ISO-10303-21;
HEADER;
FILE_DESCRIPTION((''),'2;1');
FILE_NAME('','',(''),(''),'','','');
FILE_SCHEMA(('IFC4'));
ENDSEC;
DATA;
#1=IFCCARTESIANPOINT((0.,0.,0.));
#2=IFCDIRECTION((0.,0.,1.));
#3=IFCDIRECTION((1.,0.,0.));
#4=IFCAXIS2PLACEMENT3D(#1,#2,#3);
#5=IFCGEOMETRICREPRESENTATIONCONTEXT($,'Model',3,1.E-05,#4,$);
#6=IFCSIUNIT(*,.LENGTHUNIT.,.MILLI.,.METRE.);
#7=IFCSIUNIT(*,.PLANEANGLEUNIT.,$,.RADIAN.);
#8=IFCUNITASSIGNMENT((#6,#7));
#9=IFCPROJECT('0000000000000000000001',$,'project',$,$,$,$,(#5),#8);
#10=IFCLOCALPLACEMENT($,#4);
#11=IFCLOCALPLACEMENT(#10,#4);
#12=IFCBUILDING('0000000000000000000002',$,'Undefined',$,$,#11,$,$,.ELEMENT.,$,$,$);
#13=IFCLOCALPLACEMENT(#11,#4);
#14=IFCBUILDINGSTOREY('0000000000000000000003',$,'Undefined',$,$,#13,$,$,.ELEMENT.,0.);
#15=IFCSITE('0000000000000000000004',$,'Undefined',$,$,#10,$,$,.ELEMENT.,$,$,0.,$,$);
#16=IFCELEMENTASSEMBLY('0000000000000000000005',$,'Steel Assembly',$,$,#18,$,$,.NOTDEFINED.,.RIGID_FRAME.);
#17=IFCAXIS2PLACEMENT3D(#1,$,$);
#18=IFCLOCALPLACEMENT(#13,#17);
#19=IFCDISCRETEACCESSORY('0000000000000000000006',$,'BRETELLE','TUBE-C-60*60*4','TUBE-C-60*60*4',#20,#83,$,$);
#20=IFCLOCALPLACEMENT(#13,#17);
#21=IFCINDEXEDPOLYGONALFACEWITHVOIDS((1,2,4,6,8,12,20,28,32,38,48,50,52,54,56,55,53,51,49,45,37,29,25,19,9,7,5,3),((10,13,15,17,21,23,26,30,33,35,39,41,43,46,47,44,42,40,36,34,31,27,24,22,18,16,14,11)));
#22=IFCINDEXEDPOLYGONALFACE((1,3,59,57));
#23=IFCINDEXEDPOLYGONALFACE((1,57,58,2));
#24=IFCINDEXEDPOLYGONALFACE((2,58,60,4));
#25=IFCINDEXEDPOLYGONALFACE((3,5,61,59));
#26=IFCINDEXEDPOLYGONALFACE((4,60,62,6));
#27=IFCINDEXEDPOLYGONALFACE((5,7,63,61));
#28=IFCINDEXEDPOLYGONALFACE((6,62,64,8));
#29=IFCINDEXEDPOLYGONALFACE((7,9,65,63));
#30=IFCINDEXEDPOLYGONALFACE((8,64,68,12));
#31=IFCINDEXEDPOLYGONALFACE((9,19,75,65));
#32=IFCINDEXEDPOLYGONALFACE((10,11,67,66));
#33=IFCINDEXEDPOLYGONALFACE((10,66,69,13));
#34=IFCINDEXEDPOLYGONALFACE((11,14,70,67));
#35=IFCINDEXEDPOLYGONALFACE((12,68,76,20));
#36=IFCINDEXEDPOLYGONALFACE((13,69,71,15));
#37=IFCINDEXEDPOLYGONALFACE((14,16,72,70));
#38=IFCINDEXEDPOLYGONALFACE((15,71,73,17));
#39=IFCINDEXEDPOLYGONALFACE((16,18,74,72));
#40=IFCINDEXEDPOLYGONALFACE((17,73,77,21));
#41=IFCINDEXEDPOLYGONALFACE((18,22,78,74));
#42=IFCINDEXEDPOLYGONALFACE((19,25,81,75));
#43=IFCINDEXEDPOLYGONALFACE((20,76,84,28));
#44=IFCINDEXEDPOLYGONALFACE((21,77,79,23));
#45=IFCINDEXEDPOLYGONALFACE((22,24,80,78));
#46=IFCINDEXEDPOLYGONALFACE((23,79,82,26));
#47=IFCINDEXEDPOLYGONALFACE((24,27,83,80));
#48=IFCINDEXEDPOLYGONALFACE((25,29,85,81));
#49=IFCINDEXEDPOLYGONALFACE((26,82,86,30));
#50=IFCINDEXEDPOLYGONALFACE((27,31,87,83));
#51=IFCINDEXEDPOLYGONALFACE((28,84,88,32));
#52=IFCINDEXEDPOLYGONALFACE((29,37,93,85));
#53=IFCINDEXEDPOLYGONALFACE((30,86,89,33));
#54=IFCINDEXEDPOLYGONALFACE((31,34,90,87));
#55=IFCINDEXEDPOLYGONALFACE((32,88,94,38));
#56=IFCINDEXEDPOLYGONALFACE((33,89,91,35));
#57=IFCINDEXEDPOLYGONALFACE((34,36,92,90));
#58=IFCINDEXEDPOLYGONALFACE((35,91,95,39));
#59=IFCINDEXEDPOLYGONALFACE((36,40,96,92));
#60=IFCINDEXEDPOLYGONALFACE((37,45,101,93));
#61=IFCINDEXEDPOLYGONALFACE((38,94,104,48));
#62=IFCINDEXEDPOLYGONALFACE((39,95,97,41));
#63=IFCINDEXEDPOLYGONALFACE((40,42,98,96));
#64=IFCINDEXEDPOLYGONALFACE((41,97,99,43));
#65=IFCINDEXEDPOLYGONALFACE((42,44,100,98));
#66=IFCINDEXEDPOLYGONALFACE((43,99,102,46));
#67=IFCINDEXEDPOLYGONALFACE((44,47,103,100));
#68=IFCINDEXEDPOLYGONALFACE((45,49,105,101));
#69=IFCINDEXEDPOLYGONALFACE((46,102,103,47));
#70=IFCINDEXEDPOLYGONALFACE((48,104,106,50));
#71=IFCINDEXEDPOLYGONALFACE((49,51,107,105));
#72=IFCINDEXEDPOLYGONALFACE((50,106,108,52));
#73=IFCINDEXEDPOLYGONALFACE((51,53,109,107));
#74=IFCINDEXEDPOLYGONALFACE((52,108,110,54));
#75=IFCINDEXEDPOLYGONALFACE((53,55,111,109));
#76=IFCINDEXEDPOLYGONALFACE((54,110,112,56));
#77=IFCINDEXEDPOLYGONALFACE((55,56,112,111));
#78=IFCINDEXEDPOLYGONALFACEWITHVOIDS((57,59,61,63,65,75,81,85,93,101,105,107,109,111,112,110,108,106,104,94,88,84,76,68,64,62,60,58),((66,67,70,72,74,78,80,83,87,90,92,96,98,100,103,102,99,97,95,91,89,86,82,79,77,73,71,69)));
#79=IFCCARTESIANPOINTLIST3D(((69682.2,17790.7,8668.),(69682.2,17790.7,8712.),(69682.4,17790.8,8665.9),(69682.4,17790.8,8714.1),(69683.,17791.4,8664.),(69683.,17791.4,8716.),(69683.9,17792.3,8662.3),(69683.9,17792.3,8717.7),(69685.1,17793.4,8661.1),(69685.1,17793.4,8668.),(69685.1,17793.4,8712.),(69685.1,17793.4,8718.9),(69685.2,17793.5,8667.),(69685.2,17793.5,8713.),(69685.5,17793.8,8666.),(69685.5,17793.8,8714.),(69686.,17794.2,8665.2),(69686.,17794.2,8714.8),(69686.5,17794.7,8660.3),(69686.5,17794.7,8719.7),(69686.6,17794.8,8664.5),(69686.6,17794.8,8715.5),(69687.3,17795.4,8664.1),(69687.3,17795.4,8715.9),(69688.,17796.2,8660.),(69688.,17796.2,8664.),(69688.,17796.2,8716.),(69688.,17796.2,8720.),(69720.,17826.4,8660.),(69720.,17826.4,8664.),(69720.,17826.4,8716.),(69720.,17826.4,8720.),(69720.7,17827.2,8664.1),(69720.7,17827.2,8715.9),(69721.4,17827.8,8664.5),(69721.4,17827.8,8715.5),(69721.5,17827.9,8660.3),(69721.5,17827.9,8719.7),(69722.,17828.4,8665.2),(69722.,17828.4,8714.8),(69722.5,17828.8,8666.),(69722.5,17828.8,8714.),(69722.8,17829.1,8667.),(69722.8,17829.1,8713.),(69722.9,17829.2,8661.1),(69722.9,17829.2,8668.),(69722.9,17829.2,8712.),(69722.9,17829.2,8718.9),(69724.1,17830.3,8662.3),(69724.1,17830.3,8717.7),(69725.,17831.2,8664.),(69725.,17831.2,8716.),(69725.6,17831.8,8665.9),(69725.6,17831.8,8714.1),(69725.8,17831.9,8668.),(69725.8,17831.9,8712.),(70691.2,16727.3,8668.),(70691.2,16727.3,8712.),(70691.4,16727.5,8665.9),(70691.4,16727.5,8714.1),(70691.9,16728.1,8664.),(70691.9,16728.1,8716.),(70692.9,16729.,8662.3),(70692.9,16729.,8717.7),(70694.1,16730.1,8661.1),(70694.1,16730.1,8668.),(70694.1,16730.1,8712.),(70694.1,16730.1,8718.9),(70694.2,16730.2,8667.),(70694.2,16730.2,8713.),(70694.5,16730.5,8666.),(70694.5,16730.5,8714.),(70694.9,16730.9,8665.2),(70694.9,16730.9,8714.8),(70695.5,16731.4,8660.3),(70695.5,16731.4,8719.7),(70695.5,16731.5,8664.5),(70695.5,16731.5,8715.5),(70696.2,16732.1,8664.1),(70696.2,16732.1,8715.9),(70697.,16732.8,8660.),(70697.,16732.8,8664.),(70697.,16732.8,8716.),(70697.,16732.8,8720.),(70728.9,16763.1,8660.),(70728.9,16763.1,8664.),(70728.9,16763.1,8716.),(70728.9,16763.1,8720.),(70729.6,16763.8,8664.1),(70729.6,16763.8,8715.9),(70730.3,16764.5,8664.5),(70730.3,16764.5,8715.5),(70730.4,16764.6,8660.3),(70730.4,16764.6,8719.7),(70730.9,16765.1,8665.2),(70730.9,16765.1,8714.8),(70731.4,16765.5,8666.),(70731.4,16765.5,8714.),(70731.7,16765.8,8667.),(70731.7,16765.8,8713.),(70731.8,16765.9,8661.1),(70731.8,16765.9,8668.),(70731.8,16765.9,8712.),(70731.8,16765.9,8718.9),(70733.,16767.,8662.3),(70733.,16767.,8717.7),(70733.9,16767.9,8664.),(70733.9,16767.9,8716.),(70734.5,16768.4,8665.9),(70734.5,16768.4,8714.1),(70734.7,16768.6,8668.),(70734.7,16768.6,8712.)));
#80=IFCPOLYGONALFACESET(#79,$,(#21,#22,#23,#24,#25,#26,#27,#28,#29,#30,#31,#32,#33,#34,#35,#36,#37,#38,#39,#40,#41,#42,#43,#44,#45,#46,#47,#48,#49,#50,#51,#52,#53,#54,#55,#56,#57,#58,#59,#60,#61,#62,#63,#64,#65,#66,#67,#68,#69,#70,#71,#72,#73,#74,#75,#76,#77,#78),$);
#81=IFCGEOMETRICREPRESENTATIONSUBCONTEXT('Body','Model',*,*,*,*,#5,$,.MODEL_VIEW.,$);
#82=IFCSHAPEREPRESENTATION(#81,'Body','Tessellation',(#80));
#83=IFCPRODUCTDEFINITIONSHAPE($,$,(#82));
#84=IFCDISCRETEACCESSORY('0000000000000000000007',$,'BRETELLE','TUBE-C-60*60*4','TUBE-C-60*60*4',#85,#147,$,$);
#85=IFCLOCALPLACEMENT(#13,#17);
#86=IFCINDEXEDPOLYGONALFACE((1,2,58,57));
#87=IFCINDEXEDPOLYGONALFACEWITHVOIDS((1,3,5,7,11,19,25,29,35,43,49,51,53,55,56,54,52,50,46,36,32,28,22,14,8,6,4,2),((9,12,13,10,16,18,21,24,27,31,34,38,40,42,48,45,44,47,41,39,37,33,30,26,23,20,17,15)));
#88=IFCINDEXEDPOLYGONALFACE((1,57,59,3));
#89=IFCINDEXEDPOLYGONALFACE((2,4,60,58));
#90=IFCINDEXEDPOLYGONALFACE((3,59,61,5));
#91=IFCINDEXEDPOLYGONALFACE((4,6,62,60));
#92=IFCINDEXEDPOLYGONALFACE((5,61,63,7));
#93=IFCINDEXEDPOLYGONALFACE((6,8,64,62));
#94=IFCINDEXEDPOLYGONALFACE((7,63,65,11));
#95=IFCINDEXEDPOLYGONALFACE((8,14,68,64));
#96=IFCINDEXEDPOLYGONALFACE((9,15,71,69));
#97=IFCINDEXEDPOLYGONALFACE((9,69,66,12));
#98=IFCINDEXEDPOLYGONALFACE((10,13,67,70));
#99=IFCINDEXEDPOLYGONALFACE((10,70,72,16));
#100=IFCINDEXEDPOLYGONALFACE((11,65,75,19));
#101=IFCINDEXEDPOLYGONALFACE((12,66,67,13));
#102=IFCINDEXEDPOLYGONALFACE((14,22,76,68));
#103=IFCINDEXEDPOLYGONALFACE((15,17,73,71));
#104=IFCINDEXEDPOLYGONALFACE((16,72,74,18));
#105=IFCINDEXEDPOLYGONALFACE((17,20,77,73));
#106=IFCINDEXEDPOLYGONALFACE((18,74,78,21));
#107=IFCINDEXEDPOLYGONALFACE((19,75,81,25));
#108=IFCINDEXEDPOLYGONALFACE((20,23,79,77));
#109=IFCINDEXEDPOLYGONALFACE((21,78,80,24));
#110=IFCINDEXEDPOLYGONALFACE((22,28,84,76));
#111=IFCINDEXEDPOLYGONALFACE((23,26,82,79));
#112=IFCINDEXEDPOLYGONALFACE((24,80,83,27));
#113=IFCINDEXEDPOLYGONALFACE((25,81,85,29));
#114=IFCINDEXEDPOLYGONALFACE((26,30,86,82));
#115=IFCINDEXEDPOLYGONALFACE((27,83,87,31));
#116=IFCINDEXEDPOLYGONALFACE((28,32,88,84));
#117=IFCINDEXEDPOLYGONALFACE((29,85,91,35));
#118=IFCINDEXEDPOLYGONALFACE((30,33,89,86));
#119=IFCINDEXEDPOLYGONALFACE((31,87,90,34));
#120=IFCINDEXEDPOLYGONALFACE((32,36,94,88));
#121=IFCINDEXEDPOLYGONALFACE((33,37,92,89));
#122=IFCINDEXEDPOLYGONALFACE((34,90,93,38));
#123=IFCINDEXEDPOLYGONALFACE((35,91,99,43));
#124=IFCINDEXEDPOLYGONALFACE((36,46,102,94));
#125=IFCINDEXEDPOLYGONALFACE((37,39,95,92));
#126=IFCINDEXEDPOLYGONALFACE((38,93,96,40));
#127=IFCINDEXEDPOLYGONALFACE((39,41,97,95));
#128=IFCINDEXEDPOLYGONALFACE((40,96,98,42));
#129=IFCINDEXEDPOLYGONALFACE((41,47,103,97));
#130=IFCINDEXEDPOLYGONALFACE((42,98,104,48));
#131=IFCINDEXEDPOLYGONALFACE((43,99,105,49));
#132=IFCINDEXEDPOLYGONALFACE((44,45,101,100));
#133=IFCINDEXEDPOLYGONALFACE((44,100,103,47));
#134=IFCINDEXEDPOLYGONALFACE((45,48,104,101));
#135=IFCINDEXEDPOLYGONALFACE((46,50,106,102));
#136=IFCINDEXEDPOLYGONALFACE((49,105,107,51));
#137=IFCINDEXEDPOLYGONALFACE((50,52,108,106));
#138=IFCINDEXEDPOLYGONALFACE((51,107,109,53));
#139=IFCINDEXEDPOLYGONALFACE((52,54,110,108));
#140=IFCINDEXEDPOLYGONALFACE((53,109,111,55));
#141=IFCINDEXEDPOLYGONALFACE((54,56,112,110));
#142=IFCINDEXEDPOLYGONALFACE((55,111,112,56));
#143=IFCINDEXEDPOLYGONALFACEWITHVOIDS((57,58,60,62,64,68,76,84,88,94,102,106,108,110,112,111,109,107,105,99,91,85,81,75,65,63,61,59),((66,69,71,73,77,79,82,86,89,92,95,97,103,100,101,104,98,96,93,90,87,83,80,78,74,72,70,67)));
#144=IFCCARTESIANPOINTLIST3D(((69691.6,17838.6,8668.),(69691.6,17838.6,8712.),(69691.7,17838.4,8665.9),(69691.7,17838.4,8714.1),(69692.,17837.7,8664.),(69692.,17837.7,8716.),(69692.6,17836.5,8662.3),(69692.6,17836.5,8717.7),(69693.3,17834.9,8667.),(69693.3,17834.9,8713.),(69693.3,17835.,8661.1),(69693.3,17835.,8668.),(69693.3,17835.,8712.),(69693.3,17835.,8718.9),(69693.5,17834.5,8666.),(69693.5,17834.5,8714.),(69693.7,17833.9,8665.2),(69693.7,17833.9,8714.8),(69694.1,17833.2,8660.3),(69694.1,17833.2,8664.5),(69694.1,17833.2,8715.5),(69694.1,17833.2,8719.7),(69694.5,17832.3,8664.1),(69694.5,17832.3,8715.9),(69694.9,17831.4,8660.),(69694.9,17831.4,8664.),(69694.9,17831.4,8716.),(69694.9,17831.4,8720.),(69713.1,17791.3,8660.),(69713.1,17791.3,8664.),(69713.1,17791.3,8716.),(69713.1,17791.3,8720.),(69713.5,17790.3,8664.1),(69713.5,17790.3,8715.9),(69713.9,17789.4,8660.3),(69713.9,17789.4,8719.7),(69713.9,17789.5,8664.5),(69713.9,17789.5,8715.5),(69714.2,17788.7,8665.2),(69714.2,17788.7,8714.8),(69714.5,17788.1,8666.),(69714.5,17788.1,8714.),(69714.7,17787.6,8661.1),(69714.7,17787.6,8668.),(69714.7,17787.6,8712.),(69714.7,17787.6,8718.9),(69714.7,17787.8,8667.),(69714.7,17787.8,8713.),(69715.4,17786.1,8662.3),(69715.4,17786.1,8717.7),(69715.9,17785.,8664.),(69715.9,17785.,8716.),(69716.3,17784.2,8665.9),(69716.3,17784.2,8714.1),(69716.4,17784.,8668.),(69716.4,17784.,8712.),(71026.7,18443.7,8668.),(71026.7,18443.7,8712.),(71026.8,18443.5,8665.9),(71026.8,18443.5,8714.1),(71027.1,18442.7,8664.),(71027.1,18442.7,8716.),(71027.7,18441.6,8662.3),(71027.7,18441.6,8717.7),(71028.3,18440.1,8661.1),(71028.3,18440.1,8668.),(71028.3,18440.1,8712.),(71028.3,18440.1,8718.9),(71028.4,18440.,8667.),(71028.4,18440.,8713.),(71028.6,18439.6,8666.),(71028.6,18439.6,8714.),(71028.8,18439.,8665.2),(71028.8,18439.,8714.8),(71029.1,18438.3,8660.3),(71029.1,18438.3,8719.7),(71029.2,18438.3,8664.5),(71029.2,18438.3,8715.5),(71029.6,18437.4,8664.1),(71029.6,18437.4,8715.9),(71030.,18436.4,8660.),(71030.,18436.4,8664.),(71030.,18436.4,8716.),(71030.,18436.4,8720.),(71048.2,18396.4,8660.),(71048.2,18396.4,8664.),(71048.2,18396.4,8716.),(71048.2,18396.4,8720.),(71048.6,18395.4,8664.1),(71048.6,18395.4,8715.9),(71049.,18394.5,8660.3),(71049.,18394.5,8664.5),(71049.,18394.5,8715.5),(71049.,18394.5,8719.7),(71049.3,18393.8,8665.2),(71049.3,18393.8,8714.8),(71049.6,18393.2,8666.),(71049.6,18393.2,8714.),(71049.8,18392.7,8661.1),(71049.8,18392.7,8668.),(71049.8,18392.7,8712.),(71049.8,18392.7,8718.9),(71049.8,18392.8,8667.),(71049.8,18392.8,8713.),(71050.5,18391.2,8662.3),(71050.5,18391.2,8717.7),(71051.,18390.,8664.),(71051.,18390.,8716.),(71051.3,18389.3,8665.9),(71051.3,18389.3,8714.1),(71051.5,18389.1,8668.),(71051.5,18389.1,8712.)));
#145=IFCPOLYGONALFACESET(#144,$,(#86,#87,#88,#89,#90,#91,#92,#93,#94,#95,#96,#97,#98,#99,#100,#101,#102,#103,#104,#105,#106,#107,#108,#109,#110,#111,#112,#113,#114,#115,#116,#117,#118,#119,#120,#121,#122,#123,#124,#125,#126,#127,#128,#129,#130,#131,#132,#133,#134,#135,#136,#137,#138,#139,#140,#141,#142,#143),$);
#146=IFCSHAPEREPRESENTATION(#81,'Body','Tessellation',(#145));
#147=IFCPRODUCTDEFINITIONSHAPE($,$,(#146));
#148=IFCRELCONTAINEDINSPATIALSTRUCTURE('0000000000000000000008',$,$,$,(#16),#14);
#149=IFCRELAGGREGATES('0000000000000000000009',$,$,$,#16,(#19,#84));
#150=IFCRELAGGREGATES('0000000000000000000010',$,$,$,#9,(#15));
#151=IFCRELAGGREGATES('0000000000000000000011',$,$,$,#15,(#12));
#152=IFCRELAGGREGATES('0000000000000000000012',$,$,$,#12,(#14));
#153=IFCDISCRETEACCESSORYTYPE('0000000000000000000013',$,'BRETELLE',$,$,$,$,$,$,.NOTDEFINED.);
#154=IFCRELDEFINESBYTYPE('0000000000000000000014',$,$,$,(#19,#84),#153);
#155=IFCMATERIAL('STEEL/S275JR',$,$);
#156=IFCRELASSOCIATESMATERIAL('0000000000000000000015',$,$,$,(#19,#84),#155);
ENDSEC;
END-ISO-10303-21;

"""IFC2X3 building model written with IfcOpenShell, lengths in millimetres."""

from ifc_helpers import new_model, si_unit, frame, origin_with_axes, origin_2d_with_axis, place, context, subcontext, project, spatial, hollow_rectangle, extrude, material, type_object, element, aggregate, save


model = new_model("IFC2X3")

# Units and contexts
model_context = context("Model", 3, precision=1e-05, world=origin_with_axes())
body_context = subcontext(model_context, "Body", "Model", "MODEL_VIEW")
ifc_project = project(units=[si_unit("LENGTHUNIT", "METRE", prefix="MILLI"), si_unit("PLANEANGLEUNIT", "RADIAN")], contexts=[model_context])

# Site, building, storey
site_placement = place(None, origin_with_axes())
site = spatial("IfcSite", under=ifc_project, at=site_placement, Name="Undefined", CompositionType="ELEMENT", RefElevation=0.0)
building_placement = place(site_placement, origin_with_axes())
building = spatial("IfcBuilding", under=site, at=building_placement, Name="Undefined", CompositionType="ELEMENT")
storey_placement = place(building_placement, origin_with_axes())
storey = spatial("IfcBuildingStorey", under=building, at=storey_placement, Name="Undefined", CompositionType="ELEMENT", Elevation=0.0)

# Shared definitions
ifc_material = material(Name="STEEL/S275JR")

# Element assembly, discrete accessories
assembly_1_placement = place(storey_placement, origin_with_axes())
assembly_1 = element("IfcElementAssembly", 1, at=assembly_1_placement, inside=storey, Name="Steel Assembly", AssemblyPlace="NOTDEFINED", PredefinedType="RIGID_FRAME")
discrete_accessory_type_1 = type_object("IfcDiscreteAccessoryType", Name="BRETELLE")
discrete_accessory_1_placement = place(assembly_1_placement, frame((69704.0, 17811.3, 8690.0), z_axis=(0.725415, 0.688312, 0.0), x_axis=(0.688312, -0.725415, 0.0)))
discrete_accessory_1 = element("IfcDiscreteAccessory", 2, at=discrete_accessory_1_placement, type_object=discrete_accessory_type_1, material=ifc_material, Name="BRETELLE", Description="TUBE-C-60*60*4", ObjectType="TUBE-C-60*60*4", context=body_context, shape_type="SweptSolid", body=[
    extrude(hollow_rectangle(XDim=60.0, YDim=60.0, WallThickness=4.0, InnerFilletRadius=4.0, OuterFilletRadius=8.0, at=origin_2d_with_axis()), frame((1465.8, 0.0, 0.0), z_axis=(-1.0, 0.0, 0.0), x_axis=(0.0, -1.0, 0.0)), (0.0, 0.0, 1.0), 1465.8),
])
discrete_accessory_2_placement = place(assembly_1_placement, frame((71039.1, 18416.4, 8690.0), z_axis=(-0.412798, 0.910823, 0.0), x_axis=(-0.910823, -0.412798, 0.0)))
discrete_accessory_2 = element("IfcDiscreteAccessory", 3, at=discrete_accessory_2_placement, type_object=discrete_accessory_type_1, material=ifc_material, Name="BRETELLE", Description="TUBE-C-60*60*4", ObjectType="TUBE-C-60*60*4", context=body_context, shape_type="SweptSolid", body=[
    extrude(hollow_rectangle(XDim=60.0, YDim=60.0, WallThickness=4.0, InnerFilletRadius=4.0, OuterFilletRadius=8.0, at=origin_2d_with_axis()), frame((1465.8, 0.0, 0.0), z_axis=(-1.0, 0.0, 0.0), x_axis=(0.0, -1.0, 0.0)), (0.0, 0.0, 1.0), 1465.8),
])
aggregate(assembly_1, [discrete_accessory_1, discrete_accessory_2])

save(model, "model.ifc")
